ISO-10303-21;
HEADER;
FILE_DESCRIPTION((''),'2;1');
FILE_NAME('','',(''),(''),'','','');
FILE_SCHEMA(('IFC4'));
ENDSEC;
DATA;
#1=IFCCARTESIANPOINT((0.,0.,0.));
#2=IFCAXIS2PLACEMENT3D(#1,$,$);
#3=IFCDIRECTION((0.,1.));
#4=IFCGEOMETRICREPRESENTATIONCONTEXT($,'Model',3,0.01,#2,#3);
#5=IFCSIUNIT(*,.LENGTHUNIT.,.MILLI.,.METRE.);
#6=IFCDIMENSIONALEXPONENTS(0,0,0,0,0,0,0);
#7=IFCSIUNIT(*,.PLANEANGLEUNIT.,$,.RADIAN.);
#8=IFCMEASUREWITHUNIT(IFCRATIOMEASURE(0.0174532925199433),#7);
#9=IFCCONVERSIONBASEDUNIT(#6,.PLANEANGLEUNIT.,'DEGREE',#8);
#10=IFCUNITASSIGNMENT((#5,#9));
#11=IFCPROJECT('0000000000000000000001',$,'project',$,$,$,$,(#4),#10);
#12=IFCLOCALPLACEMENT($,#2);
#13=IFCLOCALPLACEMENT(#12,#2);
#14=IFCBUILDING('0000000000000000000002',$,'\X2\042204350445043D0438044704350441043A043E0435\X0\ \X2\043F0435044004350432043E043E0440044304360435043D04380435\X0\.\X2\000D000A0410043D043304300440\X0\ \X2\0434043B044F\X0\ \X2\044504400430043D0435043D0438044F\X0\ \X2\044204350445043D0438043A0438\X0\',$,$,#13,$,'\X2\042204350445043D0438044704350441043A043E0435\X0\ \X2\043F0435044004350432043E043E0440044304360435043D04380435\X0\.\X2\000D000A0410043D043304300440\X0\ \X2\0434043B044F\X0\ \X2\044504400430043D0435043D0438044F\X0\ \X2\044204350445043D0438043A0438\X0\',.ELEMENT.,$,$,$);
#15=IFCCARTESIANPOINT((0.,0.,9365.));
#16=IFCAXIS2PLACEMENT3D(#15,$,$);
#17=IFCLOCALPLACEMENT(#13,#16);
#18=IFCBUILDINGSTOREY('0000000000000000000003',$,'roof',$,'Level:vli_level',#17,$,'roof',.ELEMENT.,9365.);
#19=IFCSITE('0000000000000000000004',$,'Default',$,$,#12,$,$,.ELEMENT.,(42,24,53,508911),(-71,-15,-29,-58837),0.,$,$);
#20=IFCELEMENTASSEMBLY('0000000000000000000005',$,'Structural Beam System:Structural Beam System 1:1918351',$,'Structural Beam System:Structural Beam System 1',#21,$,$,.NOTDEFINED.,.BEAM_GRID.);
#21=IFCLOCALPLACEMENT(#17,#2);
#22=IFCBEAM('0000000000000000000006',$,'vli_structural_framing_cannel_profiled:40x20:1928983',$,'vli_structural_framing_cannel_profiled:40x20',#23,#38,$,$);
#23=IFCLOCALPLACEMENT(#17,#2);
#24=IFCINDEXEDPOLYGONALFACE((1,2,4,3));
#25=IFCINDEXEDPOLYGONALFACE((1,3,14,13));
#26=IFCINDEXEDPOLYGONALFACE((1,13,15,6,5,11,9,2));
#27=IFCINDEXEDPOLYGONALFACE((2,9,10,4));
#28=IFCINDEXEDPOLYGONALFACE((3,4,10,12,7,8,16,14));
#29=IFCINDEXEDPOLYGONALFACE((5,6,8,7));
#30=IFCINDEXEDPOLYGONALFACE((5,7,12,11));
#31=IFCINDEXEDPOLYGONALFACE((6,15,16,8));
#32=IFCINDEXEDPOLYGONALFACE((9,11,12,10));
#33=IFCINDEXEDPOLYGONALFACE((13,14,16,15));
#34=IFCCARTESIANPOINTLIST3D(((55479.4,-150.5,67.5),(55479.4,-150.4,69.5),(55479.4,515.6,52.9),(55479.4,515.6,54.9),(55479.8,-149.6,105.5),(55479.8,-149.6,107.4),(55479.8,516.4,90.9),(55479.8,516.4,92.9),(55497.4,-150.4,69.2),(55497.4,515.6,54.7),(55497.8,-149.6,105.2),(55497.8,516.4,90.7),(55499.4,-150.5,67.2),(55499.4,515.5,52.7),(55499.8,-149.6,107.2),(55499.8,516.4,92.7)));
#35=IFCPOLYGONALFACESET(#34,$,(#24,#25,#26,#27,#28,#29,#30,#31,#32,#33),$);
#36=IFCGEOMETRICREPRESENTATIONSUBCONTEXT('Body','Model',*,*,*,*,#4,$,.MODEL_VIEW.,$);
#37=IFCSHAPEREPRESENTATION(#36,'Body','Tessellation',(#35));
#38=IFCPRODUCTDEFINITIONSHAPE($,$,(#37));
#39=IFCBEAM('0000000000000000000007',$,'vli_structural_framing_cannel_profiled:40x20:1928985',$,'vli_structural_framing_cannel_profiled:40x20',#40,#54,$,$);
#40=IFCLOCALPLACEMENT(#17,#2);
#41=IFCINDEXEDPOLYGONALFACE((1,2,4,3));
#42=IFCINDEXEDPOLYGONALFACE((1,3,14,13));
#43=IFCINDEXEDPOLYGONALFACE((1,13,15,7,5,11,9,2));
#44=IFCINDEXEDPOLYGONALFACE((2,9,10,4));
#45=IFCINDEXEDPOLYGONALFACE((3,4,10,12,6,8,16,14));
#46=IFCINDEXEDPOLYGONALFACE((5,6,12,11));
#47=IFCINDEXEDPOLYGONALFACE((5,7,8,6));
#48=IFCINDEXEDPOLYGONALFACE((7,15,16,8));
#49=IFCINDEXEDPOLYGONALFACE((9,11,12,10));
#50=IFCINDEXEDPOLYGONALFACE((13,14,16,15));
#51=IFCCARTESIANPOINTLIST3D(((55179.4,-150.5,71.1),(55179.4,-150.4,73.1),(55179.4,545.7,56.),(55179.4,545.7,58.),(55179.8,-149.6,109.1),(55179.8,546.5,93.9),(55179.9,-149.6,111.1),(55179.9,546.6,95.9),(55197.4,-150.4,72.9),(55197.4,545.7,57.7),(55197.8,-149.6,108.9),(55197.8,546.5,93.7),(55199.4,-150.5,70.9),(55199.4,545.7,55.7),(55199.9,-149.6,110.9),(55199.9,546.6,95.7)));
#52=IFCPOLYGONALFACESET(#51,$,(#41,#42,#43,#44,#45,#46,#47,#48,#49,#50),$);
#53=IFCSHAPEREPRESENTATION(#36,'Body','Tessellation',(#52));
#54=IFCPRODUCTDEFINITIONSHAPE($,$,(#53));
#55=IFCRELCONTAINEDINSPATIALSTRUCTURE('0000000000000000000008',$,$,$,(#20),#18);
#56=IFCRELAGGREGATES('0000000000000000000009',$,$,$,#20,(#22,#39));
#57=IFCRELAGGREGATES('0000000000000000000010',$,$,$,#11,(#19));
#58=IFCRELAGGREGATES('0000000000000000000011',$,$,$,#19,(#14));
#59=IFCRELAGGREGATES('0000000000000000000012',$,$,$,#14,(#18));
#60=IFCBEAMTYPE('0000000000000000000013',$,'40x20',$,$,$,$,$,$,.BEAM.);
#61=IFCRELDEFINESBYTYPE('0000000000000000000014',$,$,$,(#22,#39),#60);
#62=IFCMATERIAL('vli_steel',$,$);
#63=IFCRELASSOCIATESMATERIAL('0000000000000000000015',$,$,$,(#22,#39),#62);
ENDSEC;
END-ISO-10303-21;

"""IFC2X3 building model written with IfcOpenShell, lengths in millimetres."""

from ifc_helpers import new_model, entity, si_unit, converted_unit, direction, frame, origin, place, context, subcontext, project, spatial, polyline, outline, extrude, material, type_object, element, aggregate, save


model = new_model("IFC2X3")

# Units and contexts
model_context = context("Model", 3, precision=0.01, world=origin(), true_north=direction((0.0, 1.0)))
body_context = subcontext(model_context, "Body", "Model", "MODEL_VIEW")
ifc_project = project(units=[si_unit("LENGTHUNIT", "METRE", prefix="MILLI"), converted_unit("PLANEANGLEUNIT", "DEGREE", entity("IfcRatioMeasure", 0.0174532925199433), si_unit("PLANEANGLEUNIT", "RADIAN"), dimensions=[0, 0, 0, 0, 0, 0, 0])], contexts=[model_context])

# Site, building, storey
site_placement = place(None, origin())
site = spatial("IfcSite", under=ifc_project, at=site_placement, Name="Default", CompositionType="ELEMENT", RefLatitude=(42, 24, 53, 508911), RefLongitude=(-71, -15, -29, -58837), RefElevation=0.0)
building_placement = place(site_placement, origin())
building = spatial("IfcBuilding", under=site, at=building_placement, Name="Техническое перевооружение.\r\nАнгар для хранения техники", LongName="Техническое перевооружение.\r\nАнгар для хранения техники", CompositionType="ELEMENT")
storey_placement = place(building_placement, frame((0.0, 0.0, 9365.0)))
storey = spatial("IfcBuildingStorey", under=building, at=storey_placement, Name="roof", ObjectType="Level:vli_level", LongName="roof", CompositionType="ELEMENT", Elevation=9365.0)

# Element assembly, beams
ifc_material = material(Name="vli_steel")
beam_type = type_object("IfcBeamType", Name="40x20", PredefinedType="BEAM")
assembly_1_placement = place(storey_placement, origin())
assembly_1 = element("IfcElementAssembly", 1, at=assembly_1_placement, inside=storey, Name="Structural Beam System:Structural Beam System 1:1918351", ObjectType="Structural Beam System:Structural Beam System 1", AssemblyPlace="NOTDEFINED", PredefinedType="BEAM_GRID")
beam_1_placement = place(assembly_1_placement, frame((55499.2, 517.1, 92.7), z_axis=(0.0, 0.02179, 0.999763), x_axis=(0.0, -0.999763, 0.02179)))
beam_1 = element("IfcBeam", 2, at=beam_1_placement, type_object=beam_type, material=ifc_material, Name="vli_structural_framing_cannel_profiled:40x20:1928983", ObjectType="vli_structural_framing_cannel_profiled:40x20", context=body_context, shape_type="SweptSolid", body=[
    extrude(outline(polyline([(-10.5, -20.0), (9.5, -20.0), (9.5, -18.0), (-8.5, -18.0), (-8.5, 18.0), (9.5, 18.0), (9.5, 20.0), (-10.5, 20.0), (-10.5, -20.0)])), frame((0.7, -10.1, -19.9), z_axis=(1.0, 0.0, 0.0), x_axis=(0.0, -0.999925, 0.012243)), (0.0, 0.0, 1.0), 666.2),
])
beam_2_placement = place(assembly_1_placement, frame((55199.3, 547.2, 95.7), z_axis=(0.0, 0.02179, 0.999763), x_axis=(0.0, -0.999763, 0.02179)))
beam_2 = element("IfcBeam", 3, at=beam_2_placement, type_object=beam_type, material=ifc_material, Name="vli_structural_framing_cannel_profiled:40x20:1928985", ObjectType="vli_structural_framing_cannel_profiled:40x20", context=body_context, shape_type="SweptSolid", body=[
    extrude(outline(polyline([(-10.5, -20.0), (9.5, -20.0), (9.5, -18.0), (-8.5, -18.0), (-8.5, 18.0), (9.5, 18.0), (9.5, 20.0), (-10.5, 20.0), (-10.5, -20.0)])), frame((0.7, -10.1, -19.9), z_axis=(1.0, 0.0, 0.0), x_axis=(0.0, -0.999925, 0.012243)), (0.0, 0.0, 1.0), 696.3),
])
aggregate(assembly_1, [beam_1, beam_2])

save(model, "model.ifc")
